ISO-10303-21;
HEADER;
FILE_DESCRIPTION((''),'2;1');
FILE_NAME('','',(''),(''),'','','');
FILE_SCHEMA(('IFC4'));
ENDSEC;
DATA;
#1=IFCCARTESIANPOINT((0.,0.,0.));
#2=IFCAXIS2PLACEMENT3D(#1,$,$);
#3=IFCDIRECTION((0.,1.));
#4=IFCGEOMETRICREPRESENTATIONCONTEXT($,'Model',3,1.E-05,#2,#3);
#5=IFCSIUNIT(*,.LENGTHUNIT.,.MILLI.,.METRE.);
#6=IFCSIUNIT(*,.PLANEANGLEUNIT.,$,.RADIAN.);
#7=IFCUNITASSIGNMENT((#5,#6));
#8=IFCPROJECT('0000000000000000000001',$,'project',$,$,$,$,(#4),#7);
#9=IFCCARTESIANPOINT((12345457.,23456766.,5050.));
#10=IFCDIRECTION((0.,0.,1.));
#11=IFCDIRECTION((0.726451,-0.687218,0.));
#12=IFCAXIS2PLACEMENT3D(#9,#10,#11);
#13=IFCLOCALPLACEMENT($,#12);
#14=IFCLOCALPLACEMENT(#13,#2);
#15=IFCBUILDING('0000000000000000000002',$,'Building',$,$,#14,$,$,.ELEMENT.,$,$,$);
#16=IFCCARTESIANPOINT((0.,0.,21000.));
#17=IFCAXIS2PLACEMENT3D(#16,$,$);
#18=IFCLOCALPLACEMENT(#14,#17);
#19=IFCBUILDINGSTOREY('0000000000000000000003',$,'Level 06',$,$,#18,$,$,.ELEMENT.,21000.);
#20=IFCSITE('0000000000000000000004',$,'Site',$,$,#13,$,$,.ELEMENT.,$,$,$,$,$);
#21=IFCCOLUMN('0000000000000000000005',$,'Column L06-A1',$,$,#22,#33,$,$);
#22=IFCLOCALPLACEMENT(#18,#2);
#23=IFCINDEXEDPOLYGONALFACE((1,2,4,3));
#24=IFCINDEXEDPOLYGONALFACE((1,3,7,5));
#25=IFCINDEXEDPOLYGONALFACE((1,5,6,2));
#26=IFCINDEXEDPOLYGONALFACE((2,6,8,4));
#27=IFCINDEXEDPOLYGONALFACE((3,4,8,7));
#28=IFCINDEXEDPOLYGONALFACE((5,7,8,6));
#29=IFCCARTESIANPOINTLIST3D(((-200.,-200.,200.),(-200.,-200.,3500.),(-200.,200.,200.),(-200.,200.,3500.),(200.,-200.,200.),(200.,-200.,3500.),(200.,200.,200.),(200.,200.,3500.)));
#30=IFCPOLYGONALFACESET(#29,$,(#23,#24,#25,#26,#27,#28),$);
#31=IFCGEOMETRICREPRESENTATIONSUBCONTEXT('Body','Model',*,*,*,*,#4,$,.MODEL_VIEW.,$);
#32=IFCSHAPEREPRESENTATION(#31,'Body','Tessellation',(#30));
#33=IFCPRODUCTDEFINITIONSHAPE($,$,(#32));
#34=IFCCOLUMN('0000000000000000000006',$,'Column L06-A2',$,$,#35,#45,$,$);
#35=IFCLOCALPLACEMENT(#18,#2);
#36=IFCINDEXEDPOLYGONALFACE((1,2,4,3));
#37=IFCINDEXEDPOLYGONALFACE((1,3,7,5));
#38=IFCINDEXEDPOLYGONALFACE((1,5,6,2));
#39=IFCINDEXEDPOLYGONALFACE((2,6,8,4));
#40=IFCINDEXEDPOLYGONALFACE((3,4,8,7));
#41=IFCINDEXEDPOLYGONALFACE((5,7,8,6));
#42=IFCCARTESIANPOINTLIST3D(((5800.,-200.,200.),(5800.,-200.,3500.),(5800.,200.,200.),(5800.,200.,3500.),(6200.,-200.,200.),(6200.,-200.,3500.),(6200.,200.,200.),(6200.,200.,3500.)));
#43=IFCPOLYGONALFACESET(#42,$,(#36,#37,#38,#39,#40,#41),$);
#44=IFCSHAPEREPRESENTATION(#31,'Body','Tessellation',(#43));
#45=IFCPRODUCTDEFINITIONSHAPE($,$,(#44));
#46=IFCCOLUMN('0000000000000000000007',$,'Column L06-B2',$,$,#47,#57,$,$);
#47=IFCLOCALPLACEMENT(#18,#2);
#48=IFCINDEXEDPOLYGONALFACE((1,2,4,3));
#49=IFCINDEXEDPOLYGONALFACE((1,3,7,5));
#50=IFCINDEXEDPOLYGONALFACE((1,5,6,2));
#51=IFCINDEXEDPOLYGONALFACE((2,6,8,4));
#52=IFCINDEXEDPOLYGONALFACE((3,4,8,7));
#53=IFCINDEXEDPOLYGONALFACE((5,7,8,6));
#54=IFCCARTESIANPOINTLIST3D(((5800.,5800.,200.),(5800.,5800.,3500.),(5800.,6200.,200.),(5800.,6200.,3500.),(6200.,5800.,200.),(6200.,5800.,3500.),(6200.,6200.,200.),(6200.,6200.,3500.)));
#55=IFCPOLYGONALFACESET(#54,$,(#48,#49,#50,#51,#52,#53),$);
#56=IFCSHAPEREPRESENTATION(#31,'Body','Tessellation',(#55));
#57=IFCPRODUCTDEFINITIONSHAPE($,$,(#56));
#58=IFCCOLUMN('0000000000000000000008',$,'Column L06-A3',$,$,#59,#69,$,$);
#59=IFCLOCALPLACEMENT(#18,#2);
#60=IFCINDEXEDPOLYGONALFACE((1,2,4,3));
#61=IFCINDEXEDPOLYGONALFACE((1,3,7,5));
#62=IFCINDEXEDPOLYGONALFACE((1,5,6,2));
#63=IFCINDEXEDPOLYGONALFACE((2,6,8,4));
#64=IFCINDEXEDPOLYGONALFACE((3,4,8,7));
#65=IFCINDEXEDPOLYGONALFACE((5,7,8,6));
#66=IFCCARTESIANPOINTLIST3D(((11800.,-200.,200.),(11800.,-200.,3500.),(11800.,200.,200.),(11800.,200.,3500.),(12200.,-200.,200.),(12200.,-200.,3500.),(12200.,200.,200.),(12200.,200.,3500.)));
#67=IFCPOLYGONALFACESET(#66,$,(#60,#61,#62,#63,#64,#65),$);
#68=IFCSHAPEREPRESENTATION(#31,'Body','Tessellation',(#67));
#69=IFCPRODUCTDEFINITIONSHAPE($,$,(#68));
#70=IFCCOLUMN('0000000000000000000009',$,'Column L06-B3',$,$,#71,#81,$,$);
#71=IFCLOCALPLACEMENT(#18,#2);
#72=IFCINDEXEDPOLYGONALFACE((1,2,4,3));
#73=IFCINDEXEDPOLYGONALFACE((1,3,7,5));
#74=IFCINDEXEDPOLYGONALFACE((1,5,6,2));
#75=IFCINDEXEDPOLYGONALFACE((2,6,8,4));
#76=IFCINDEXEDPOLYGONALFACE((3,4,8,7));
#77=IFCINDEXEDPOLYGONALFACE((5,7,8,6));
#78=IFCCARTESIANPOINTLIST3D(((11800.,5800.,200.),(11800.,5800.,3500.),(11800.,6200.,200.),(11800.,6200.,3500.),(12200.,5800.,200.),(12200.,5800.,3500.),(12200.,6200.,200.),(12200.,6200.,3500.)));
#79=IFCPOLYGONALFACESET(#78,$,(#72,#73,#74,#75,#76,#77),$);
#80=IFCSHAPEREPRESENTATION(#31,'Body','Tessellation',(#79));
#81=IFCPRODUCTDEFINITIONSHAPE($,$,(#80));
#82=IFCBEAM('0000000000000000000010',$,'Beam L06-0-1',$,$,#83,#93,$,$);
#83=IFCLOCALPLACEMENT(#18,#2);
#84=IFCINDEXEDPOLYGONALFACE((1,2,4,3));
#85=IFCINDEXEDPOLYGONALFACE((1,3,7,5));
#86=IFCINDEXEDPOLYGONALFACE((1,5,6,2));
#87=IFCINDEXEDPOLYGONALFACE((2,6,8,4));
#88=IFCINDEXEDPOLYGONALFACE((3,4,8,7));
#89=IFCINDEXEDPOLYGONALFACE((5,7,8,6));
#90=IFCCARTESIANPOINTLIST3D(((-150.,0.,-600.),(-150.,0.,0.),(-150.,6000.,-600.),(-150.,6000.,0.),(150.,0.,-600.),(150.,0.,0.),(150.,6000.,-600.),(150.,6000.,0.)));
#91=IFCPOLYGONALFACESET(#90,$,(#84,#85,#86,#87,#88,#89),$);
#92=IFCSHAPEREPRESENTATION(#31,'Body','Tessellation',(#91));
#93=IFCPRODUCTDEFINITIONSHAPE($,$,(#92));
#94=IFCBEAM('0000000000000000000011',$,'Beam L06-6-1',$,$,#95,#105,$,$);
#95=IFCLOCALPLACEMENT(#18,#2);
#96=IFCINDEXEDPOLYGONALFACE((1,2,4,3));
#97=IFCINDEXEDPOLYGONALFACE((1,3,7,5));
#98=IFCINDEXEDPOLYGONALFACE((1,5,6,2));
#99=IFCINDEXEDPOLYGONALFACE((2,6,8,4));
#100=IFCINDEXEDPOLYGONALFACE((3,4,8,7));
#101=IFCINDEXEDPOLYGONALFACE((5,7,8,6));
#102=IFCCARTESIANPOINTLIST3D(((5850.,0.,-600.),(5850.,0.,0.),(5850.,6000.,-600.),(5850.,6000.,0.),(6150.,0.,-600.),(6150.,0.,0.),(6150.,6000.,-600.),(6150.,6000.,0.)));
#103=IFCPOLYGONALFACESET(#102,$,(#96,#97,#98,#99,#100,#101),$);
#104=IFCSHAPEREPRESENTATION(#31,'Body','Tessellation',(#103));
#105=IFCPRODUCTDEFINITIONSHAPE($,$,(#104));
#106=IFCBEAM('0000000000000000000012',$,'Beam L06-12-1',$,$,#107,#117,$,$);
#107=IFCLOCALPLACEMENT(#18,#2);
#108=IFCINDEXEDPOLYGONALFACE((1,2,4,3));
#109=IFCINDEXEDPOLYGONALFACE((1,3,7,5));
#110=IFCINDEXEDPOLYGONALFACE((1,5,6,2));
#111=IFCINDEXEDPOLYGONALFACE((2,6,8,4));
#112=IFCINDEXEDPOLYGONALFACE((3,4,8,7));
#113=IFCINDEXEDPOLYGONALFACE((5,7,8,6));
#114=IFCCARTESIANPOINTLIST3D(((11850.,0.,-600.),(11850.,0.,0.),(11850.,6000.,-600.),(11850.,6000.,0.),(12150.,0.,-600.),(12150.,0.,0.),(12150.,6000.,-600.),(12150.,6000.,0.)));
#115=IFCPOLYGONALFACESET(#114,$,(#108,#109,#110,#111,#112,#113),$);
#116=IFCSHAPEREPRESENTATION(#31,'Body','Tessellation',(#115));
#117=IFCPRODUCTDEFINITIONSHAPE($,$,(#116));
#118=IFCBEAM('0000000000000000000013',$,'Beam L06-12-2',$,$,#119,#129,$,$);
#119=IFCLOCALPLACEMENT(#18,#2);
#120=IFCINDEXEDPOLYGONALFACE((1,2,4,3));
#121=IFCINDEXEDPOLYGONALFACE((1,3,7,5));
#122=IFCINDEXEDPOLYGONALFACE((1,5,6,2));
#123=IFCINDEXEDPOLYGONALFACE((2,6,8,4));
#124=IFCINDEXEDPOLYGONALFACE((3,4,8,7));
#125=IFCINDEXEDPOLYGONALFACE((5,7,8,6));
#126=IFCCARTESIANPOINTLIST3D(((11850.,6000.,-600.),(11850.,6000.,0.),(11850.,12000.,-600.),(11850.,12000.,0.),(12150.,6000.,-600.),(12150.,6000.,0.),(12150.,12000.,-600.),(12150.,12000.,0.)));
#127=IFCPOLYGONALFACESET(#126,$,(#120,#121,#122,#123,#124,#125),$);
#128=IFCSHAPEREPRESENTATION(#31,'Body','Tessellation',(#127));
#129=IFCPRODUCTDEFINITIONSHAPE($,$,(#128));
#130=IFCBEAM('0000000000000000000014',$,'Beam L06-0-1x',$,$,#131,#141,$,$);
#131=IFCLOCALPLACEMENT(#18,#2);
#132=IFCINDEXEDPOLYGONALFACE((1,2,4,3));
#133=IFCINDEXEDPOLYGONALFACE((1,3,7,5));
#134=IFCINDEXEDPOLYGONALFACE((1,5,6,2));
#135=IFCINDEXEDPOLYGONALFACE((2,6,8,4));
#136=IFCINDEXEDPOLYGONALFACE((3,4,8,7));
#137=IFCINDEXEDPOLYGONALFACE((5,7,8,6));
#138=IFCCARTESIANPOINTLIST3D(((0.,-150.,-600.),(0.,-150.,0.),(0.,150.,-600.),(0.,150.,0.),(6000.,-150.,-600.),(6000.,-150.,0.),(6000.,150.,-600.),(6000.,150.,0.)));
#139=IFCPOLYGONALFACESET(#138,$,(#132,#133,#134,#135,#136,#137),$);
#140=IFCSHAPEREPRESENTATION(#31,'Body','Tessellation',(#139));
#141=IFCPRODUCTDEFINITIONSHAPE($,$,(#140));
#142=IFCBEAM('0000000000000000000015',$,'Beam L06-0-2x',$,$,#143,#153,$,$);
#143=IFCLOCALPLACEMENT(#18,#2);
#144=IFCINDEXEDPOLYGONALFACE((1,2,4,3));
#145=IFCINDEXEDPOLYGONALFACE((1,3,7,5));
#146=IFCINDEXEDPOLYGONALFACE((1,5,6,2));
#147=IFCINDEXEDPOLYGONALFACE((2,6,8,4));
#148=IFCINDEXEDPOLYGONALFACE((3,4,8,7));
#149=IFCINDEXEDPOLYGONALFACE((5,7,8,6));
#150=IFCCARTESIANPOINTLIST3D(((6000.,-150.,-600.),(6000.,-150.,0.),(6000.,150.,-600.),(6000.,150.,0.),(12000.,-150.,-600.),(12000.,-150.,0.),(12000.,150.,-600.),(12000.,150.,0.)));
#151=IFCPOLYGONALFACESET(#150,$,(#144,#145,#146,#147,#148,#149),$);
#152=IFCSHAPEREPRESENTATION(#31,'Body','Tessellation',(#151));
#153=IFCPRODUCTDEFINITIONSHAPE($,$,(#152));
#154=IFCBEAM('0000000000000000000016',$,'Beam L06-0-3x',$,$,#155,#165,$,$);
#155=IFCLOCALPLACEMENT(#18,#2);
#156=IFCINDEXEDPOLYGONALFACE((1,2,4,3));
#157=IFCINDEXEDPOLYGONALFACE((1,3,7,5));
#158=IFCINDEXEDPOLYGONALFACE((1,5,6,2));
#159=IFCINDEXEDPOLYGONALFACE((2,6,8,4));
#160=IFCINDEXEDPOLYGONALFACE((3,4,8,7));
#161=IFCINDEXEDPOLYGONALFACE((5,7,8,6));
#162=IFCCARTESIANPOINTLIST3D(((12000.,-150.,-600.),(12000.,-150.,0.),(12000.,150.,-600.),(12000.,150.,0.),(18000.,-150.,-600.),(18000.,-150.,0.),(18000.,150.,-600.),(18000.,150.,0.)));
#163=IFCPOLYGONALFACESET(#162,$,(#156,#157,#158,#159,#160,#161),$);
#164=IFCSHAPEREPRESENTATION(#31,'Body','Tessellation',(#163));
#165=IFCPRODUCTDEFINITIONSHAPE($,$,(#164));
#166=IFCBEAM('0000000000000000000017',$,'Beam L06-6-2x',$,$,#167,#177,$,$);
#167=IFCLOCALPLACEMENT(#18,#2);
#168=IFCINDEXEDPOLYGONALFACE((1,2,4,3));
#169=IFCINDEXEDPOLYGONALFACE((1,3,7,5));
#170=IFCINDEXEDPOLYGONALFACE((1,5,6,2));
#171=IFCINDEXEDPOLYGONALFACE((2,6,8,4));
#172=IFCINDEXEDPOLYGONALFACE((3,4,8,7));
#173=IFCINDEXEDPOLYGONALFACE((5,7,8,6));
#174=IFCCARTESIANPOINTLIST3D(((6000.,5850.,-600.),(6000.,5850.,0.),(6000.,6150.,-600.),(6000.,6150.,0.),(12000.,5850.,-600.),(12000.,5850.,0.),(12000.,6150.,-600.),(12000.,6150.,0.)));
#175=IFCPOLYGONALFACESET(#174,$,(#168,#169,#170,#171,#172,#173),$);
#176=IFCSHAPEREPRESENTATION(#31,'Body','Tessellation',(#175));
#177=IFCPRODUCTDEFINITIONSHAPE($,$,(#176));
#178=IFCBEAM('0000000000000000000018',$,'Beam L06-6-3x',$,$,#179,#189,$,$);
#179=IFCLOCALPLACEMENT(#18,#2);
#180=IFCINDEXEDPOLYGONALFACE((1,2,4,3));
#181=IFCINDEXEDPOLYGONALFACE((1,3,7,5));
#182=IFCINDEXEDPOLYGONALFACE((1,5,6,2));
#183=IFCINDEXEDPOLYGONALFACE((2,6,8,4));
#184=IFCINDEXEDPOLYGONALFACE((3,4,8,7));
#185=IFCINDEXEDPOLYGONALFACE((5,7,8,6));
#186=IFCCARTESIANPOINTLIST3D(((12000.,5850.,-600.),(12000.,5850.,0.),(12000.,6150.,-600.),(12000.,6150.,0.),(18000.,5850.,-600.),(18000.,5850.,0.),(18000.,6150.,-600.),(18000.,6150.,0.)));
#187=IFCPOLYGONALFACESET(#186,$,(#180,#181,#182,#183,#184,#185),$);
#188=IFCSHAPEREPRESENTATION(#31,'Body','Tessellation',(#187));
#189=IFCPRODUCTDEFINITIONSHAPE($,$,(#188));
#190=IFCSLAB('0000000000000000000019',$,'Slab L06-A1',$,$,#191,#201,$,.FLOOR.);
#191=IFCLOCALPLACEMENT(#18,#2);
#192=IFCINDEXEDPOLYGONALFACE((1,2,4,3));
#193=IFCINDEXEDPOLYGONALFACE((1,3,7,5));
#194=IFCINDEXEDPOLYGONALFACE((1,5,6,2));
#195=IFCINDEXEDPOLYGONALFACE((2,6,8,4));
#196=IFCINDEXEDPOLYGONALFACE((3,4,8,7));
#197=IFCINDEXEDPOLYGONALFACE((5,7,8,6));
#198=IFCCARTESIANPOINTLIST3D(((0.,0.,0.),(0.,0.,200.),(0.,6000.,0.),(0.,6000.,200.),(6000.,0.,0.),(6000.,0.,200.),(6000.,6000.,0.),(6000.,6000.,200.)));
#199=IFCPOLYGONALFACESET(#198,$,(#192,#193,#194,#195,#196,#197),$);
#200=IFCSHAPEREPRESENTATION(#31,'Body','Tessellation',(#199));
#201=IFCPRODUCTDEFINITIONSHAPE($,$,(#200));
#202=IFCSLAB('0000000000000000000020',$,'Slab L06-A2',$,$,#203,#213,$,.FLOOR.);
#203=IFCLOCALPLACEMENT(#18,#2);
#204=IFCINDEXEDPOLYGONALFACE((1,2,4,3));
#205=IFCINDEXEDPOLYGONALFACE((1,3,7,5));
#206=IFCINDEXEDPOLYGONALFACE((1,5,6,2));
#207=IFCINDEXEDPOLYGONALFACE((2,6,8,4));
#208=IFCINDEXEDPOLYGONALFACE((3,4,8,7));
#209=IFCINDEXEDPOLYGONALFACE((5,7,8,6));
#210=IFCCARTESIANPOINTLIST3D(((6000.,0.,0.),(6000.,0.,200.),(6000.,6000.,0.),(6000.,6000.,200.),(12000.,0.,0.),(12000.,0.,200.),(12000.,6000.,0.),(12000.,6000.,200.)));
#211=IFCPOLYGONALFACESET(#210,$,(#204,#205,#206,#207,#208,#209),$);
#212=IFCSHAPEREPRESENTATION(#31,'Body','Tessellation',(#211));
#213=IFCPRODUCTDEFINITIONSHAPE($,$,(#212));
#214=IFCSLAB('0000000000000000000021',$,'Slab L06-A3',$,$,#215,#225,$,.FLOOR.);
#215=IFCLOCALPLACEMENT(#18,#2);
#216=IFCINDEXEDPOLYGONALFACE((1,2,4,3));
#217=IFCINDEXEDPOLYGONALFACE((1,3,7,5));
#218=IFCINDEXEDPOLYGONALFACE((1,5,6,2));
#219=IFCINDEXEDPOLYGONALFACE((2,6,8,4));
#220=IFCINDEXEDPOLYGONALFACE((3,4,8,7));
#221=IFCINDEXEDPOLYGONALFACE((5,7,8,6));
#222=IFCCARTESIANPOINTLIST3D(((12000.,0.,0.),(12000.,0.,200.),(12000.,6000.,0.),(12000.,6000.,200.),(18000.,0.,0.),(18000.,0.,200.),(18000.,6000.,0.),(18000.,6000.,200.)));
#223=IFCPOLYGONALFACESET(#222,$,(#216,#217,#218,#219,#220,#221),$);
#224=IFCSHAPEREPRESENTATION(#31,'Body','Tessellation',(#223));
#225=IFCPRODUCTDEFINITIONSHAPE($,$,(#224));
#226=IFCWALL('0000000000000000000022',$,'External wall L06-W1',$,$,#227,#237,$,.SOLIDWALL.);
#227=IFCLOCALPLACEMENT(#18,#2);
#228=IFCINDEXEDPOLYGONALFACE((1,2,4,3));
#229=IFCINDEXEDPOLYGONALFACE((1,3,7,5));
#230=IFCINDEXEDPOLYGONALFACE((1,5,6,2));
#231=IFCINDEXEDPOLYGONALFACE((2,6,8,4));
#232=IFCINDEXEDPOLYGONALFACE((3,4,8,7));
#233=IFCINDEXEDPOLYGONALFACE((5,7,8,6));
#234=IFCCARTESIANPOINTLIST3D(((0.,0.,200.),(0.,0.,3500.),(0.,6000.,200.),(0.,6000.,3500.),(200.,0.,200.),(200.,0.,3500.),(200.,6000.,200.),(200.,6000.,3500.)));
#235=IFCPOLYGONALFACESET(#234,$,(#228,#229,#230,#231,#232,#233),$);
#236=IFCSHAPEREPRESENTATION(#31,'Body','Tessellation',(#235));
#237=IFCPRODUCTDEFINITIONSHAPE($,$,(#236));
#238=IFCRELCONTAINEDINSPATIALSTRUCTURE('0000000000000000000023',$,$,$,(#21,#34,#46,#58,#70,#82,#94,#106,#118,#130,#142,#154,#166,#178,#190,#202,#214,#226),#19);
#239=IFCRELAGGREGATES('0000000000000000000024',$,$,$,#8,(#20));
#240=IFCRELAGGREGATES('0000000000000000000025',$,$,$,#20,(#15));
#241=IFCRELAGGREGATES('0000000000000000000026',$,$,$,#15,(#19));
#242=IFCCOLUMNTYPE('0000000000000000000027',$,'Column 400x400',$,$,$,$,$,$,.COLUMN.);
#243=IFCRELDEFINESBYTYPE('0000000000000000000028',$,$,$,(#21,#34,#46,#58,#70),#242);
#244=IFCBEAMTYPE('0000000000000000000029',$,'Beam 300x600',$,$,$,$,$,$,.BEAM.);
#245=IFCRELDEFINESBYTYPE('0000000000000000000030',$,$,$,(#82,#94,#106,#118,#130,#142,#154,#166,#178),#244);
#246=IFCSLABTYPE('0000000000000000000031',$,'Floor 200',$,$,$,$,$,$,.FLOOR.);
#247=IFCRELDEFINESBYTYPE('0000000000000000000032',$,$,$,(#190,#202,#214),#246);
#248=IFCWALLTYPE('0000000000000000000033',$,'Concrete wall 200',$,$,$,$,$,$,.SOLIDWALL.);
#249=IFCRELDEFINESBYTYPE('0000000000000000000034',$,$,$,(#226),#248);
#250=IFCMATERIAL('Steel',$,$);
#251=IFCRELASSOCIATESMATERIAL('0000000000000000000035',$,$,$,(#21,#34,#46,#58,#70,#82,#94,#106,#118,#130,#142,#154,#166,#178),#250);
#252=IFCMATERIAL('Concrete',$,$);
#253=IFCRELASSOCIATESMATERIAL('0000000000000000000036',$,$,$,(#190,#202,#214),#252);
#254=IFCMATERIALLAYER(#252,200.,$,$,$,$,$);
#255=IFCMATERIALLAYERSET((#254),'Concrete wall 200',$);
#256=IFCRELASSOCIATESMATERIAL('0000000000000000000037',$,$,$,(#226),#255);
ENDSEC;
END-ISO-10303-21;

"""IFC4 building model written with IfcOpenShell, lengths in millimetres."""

from ifc_helpers import new_model, si_unit, direction, frame, origin, place, context, subcontext, project, spatial, rectangle, extrude, material, layer, layer_set, layer_usage, type_object, element, save


model = new_model("IFC4")

# Units and contexts
model_context = context("Model", 3, precision=1e-05, world=origin(), true_north=direction((0.0, 1.0)))
body_context = subcontext(model_context, "Body", "Model", "MODEL_VIEW")
ifc_project = project(units=[si_unit("LENGTHUNIT", "METRE", prefix="MILLI"), si_unit("PLANEANGLEUNIT", "RADIAN")], contexts=[model_context])

# Site, building, storey
site_placement = place(None, frame((12345457.0, 23456766.0, 5050.0), z_axis=(0.0, 0.0, 1.0), x_axis=(0.726451, -0.687218, 0.0)))
site = spatial("IfcSite", under=ifc_project, at=site_placement, Name="Site", CompositionType="ELEMENT")
building_placement = place(site_placement, origin())
building = spatial("IfcBuilding", under=site, at=building_placement, Name="Building", CompositionType="ELEMENT")
storey_placement = place(building_placement, frame((0.0, 0.0, 21000.0)))
storey = spatial("IfcBuildingStorey", under=building, at=storey_placement, Name="Level 06", CompositionType="ELEMENT", Elevation=21000.0)

# Columns
ifc_material_1 = material(Name="Steel")
column_type = type_object("IfcColumnType", Name="Column 400x400", PredefinedType="COLUMN")
for number, where, name in (
    (1, (-200.0, -200.0, 200.0), "Column L06-A1"),
    (2, (5800.0, -200.0, 200.0), "Column L06-A2"),
    (3, (5800.0, 5800.0, 200.0), "Column L06-B2"),
    (4, (11800.0, -200.0, 200.0), "Column L06-A3"),
    (5, (11800.0, 5800.0, 200.0), "Column L06-B3"),
):
    element("IfcColumn", number, at=place(storey_placement, frame(where)), inside=storey, type_object=column_type, material=ifc_material_1, Name=name, context=body_context, shape_type="SweptSolid", body=[
        extrude(rectangle(XDim=400.0, YDim=400.0), frame((200.0, 200.0, 0.0)), (0.0, 0.0, 1.0), 3300.0),
    ])

# Beams
beam_type = type_object("IfcBeamType", Name="Beam 300x600", PredefinedType="BEAM")
for number, where, name in (
    (6, (-150.0, 0.0, -600.0), "Beam L06-0-1"),
    (7, (5850.0, 0.0, -600.0), "Beam L06-6-1"),
    (8, (11850.0, 0.0, -600.0), "Beam L06-12-1"),
    (9, (11850.0, 6000.0, -600.0), "Beam L06-12-2"),
):
    element("IfcBeam", number, at=place(storey_placement, frame(where)), inside=storey, type_object=beam_type, material=ifc_material_1, Name=name, context=body_context, shape_type="SweptSolid", body=[
        extrude(rectangle(XDim=300.0, YDim=6000.0), frame((150.0, 3000.0, 0.0)), (0.0, 0.0, 1.0), 600.0),
    ])
for number, where, name in (
    (10, (0.0, -150.0, -600.0), "Beam L06-0-1x"),
    (11, (6000.0, -150.0, -600.0), "Beam L06-0-2x"),
    (12, (12000.0, -150.0, -600.0), "Beam L06-0-3x"),
    (13, (6000.0, 5850.0, -600.0), "Beam L06-6-2x"),
    (14, (12000.0, 5850.0, -600.0), "Beam L06-6-3x"),
):
    element("IfcBeam", number, at=place(storey_placement, frame(where)), inside=storey, type_object=beam_type, material=ifc_material_1, Name=name, context=body_context, shape_type="SweptSolid", body=[
        extrude(rectangle(XDim=6000.0, YDim=300.0), frame((3000.0, 150.0, 0.0)), (0.0, 0.0, 1.0), 600.0),
    ])

# Slabs
ifc_material_2 = material(Name="Concrete")
slab_type = type_object("IfcSlabType", Name="Floor 200", PredefinedType="FLOOR")
for number, where, name in (
    (15, (0.0, 0.0, 0.0), "Slab L06-A1"),
    (16, (6000.0, 0.0, 0.0), "Slab L06-A2"),
    (17, (12000.0, 0.0, 0.0), "Slab L06-A3"),
):
    element("IfcSlab", number, at=place(storey_placement, frame(where)), inside=storey, type_object=slab_type, material=ifc_material_2, Name=name, PredefinedType="FLOOR", context=body_context, shape_type="SweptSolid", body=[
        extrude(rectangle(XDim=6000.0, YDim=6000.0), frame((3000.0, 3000.0, 0.0)), (0.0, 0.0, 1.0), 200.0),
    ])

# Wall
ifc_layer_1 = layer(ifc_material_2, 200.0)
ifc_layer_set_1 = layer_set([ifc_layer_1], Name="Concrete wall 200")
ifc_layer_usage_1 = layer_usage(ifc_layer_set_1, "AXIS2", "POSITIVE", 0.0)
wall_type_1 = type_object("IfcWallType", Name="Concrete wall 200", PredefinedType="SOLIDWALL")
wall_placement = place(storey_placement, frame((0.0, 0.0, 200.0)))
element("IfcWall", 18, at=wall_placement, inside=storey, type_object=wall_type_1, material=ifc_layer_usage_1, Name="External wall L06-W1", PredefinedType="SOLIDWALL", context=body_context, shape_type="SweptSolid", body=[
    extrude(rectangle(XDim=200.0, YDim=6000.0), frame((100.0, 3000.0, 0.0)), (0.0, 0.0, 1.0), 3300.0),
])

save(model, "model.ifc")
